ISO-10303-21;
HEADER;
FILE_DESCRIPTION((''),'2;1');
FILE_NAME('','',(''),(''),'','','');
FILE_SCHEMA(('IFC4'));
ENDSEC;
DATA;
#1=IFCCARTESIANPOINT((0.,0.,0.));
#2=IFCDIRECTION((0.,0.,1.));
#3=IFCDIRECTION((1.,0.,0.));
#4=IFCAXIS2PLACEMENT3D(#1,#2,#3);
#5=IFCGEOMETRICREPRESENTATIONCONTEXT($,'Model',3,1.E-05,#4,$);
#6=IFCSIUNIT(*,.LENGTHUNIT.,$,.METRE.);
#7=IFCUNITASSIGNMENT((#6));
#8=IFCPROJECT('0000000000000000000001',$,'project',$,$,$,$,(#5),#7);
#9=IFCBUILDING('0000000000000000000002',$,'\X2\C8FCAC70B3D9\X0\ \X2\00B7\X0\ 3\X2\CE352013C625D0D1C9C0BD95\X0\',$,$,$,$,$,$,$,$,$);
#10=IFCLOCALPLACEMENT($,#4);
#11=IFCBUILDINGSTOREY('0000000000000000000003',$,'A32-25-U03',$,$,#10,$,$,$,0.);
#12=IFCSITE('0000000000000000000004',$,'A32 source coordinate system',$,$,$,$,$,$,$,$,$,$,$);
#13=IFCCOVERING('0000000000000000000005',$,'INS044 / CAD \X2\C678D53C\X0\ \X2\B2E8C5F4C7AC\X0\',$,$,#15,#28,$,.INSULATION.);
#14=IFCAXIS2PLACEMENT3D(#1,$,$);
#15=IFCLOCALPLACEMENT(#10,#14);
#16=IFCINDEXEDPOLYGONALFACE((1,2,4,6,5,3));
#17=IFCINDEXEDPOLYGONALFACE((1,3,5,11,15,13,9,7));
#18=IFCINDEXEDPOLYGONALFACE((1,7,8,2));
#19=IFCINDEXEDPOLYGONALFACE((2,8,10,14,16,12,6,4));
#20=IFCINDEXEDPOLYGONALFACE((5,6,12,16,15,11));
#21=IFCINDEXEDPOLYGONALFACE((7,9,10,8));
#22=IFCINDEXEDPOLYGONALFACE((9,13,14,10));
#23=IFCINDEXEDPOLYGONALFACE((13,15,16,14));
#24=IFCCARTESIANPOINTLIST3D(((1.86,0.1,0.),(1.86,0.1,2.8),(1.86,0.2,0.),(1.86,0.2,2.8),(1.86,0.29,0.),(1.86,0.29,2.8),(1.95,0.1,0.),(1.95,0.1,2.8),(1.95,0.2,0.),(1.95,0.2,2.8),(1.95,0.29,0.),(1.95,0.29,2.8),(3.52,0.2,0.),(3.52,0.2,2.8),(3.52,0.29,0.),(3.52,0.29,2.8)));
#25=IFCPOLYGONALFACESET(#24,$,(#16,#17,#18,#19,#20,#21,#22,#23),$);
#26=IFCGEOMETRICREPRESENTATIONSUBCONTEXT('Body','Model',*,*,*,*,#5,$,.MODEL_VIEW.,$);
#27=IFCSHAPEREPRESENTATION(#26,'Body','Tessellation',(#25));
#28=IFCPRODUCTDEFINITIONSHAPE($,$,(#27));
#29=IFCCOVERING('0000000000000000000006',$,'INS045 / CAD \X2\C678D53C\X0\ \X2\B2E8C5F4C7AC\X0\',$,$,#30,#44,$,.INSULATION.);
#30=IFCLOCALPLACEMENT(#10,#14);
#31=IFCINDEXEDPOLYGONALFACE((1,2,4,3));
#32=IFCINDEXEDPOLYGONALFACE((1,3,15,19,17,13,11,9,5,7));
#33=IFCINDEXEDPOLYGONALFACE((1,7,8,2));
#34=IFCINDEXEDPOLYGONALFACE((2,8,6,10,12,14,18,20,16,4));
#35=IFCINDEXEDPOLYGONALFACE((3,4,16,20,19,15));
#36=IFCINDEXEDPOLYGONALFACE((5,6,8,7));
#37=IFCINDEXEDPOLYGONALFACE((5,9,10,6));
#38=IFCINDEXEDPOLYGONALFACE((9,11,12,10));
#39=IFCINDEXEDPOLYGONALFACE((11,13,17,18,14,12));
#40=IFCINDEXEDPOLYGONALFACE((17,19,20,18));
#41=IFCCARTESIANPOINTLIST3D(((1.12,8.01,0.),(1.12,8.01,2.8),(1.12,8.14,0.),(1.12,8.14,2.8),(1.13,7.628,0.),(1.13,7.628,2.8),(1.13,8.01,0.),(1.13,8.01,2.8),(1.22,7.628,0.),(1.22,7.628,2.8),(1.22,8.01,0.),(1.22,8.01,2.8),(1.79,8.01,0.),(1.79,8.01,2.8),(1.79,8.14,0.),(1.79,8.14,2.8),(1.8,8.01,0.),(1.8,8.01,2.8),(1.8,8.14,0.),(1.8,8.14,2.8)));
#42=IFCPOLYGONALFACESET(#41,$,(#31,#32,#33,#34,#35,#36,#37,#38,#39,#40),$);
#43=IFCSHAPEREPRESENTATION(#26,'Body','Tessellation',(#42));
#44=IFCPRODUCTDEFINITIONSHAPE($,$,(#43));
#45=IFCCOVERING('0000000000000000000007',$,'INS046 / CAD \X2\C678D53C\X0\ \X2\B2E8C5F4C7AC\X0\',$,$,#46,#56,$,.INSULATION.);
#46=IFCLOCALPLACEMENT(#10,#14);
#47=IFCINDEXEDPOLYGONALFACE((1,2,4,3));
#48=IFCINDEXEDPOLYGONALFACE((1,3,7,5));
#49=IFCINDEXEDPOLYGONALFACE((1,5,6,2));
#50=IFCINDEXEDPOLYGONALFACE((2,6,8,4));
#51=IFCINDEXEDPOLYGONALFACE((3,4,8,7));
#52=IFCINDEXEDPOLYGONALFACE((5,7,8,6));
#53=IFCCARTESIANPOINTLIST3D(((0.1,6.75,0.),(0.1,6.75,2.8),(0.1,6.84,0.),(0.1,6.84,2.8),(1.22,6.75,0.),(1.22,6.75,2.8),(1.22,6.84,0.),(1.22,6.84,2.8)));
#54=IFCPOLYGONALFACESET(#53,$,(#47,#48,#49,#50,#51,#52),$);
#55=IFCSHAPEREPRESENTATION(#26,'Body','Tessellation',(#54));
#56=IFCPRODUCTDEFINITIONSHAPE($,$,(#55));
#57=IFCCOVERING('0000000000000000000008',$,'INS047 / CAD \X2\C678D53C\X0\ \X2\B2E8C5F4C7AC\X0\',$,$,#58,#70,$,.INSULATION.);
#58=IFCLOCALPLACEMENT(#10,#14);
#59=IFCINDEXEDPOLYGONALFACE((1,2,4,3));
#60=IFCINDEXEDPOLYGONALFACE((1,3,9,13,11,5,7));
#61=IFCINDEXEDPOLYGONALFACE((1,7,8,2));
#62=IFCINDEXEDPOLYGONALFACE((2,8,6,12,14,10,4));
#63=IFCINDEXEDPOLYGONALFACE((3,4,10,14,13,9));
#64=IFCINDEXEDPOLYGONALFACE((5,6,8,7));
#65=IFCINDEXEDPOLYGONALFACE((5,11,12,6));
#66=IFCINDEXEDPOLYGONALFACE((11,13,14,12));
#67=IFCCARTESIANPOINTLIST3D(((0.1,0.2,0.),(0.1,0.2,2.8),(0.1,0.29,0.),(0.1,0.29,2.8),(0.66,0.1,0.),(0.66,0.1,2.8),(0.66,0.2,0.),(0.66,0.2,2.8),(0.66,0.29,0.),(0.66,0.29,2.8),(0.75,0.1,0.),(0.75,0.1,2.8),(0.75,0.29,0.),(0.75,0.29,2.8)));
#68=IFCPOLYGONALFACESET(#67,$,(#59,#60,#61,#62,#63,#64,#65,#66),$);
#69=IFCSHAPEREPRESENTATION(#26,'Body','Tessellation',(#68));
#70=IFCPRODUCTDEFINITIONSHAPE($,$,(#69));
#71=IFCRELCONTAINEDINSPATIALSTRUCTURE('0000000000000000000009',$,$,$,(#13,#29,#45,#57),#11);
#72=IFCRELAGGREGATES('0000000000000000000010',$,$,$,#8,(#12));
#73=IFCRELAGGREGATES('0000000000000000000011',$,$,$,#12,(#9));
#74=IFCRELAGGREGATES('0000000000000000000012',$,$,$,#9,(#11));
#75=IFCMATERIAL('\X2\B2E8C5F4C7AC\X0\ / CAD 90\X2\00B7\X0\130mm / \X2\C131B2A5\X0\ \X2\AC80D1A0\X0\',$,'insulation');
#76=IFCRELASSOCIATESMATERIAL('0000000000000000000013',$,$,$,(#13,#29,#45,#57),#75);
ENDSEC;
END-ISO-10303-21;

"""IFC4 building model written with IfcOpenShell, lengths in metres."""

from ifc_helpers import new_model, si_unit, origin, origin_with_axes, place, context, subcontext, project, spatial, polyline, outline, extrude, material, element, save


model = new_model("IFC4")

# Units and contexts
model_context = context("Model", 3, precision=1e-05, world=origin_with_axes())
body_context = subcontext(model_context, "Body", "Model", "MODEL_VIEW")
ifc_project = project(units=[si_unit("LENGTHUNIT", "METRE")], contexts=[model_context])

# Site, building, storey
storey_placement = place(None, origin_with_axes())
site = spatial("IfcSite", under=ifc_project, Name="A32 source coordinate system")
building = spatial("IfcBuilding", under=site, Name="주거동 · 3층–옥탑지붕")
storey = spatial("IfcBuildingStorey", under=building, at=storey_placement, Name="A32-25-U03", Elevation=0.0)

# Coverings
ifc_material = material(Name="단열재 / CAD 90·130mm / 성능 검토", Category="insulation")
covering_1_placement = place(storey_placement, origin_with_axes())
element("IfcCovering", 1, at=covering_1_placement, inside=storey, material=ifc_material, Name="INS044 / CAD 외피 단열재", PredefinedType="INSULATION", context=body_context, shape_type="SweptSolid", body=[
    extrude(outline(polyline([(1.86, 0.2), (1.86, 0.29), (1.95, 0.29), (3.52, 0.29), (3.52, 0.2), (1.95, 0.2), (1.95, 0.1), (1.86, 0.1), (1.86, 0.2)])), origin(), (0.0, 0.0, 1.0), 2.8),
])
covering_2_placement = place(storey_placement, origin_with_axes())
element("IfcCovering", 2, at=covering_2_placement, inside=storey, material=ifc_material, Name="INS045 / CAD 외피 단열재", PredefinedType="INSULATION", context=body_context, shape_type="SweptSolid", body=[
    extrude(outline(polyline([(1.22, 8.01), (1.22, 7.628), (1.13, 7.628), (1.13, 8.01), (1.12, 8.01), (1.12, 8.14), (1.79, 8.14), (1.8, 8.14), (1.8, 8.01), (1.79, 8.01), (1.22, 8.01)])), origin(), (0.0, 0.0, 1.0), 2.8),
])
covering_3_placement = place(storey_placement, origin_with_axes())
element("IfcCovering", 3, at=covering_3_placement, inside=storey, material=ifc_material, Name="INS046 / CAD 외피 단열재", PredefinedType="INSULATION", context=body_context, shape_type="SweptSolid", body=[
    extrude(outline(polyline([(0.1, 6.84), (1.22, 6.84), (1.22, 6.75), (0.1, 6.75), (0.1, 6.84)])), origin(), (0.0, 0.0, 1.0), 2.8),
])
covering_4_placement = place(storey_placement, origin_with_axes())
element("IfcCovering", 4, at=covering_4_placement, inside=storey, material=ifc_material, Name="INS047 / CAD 외피 단열재", PredefinedType="INSULATION", context=body_context, shape_type="SweptSolid", body=[
    extrude(outline(polyline([(0.1, 0.2), (0.1, 0.29), (0.66, 0.29), (0.75, 0.29), (0.75, 0.1), (0.66, 0.1), (0.66, 0.2), (0.1, 0.2)])), origin(), (0.0, 0.0, 1.0), 2.8),
])

save(model, "model.ifc")
